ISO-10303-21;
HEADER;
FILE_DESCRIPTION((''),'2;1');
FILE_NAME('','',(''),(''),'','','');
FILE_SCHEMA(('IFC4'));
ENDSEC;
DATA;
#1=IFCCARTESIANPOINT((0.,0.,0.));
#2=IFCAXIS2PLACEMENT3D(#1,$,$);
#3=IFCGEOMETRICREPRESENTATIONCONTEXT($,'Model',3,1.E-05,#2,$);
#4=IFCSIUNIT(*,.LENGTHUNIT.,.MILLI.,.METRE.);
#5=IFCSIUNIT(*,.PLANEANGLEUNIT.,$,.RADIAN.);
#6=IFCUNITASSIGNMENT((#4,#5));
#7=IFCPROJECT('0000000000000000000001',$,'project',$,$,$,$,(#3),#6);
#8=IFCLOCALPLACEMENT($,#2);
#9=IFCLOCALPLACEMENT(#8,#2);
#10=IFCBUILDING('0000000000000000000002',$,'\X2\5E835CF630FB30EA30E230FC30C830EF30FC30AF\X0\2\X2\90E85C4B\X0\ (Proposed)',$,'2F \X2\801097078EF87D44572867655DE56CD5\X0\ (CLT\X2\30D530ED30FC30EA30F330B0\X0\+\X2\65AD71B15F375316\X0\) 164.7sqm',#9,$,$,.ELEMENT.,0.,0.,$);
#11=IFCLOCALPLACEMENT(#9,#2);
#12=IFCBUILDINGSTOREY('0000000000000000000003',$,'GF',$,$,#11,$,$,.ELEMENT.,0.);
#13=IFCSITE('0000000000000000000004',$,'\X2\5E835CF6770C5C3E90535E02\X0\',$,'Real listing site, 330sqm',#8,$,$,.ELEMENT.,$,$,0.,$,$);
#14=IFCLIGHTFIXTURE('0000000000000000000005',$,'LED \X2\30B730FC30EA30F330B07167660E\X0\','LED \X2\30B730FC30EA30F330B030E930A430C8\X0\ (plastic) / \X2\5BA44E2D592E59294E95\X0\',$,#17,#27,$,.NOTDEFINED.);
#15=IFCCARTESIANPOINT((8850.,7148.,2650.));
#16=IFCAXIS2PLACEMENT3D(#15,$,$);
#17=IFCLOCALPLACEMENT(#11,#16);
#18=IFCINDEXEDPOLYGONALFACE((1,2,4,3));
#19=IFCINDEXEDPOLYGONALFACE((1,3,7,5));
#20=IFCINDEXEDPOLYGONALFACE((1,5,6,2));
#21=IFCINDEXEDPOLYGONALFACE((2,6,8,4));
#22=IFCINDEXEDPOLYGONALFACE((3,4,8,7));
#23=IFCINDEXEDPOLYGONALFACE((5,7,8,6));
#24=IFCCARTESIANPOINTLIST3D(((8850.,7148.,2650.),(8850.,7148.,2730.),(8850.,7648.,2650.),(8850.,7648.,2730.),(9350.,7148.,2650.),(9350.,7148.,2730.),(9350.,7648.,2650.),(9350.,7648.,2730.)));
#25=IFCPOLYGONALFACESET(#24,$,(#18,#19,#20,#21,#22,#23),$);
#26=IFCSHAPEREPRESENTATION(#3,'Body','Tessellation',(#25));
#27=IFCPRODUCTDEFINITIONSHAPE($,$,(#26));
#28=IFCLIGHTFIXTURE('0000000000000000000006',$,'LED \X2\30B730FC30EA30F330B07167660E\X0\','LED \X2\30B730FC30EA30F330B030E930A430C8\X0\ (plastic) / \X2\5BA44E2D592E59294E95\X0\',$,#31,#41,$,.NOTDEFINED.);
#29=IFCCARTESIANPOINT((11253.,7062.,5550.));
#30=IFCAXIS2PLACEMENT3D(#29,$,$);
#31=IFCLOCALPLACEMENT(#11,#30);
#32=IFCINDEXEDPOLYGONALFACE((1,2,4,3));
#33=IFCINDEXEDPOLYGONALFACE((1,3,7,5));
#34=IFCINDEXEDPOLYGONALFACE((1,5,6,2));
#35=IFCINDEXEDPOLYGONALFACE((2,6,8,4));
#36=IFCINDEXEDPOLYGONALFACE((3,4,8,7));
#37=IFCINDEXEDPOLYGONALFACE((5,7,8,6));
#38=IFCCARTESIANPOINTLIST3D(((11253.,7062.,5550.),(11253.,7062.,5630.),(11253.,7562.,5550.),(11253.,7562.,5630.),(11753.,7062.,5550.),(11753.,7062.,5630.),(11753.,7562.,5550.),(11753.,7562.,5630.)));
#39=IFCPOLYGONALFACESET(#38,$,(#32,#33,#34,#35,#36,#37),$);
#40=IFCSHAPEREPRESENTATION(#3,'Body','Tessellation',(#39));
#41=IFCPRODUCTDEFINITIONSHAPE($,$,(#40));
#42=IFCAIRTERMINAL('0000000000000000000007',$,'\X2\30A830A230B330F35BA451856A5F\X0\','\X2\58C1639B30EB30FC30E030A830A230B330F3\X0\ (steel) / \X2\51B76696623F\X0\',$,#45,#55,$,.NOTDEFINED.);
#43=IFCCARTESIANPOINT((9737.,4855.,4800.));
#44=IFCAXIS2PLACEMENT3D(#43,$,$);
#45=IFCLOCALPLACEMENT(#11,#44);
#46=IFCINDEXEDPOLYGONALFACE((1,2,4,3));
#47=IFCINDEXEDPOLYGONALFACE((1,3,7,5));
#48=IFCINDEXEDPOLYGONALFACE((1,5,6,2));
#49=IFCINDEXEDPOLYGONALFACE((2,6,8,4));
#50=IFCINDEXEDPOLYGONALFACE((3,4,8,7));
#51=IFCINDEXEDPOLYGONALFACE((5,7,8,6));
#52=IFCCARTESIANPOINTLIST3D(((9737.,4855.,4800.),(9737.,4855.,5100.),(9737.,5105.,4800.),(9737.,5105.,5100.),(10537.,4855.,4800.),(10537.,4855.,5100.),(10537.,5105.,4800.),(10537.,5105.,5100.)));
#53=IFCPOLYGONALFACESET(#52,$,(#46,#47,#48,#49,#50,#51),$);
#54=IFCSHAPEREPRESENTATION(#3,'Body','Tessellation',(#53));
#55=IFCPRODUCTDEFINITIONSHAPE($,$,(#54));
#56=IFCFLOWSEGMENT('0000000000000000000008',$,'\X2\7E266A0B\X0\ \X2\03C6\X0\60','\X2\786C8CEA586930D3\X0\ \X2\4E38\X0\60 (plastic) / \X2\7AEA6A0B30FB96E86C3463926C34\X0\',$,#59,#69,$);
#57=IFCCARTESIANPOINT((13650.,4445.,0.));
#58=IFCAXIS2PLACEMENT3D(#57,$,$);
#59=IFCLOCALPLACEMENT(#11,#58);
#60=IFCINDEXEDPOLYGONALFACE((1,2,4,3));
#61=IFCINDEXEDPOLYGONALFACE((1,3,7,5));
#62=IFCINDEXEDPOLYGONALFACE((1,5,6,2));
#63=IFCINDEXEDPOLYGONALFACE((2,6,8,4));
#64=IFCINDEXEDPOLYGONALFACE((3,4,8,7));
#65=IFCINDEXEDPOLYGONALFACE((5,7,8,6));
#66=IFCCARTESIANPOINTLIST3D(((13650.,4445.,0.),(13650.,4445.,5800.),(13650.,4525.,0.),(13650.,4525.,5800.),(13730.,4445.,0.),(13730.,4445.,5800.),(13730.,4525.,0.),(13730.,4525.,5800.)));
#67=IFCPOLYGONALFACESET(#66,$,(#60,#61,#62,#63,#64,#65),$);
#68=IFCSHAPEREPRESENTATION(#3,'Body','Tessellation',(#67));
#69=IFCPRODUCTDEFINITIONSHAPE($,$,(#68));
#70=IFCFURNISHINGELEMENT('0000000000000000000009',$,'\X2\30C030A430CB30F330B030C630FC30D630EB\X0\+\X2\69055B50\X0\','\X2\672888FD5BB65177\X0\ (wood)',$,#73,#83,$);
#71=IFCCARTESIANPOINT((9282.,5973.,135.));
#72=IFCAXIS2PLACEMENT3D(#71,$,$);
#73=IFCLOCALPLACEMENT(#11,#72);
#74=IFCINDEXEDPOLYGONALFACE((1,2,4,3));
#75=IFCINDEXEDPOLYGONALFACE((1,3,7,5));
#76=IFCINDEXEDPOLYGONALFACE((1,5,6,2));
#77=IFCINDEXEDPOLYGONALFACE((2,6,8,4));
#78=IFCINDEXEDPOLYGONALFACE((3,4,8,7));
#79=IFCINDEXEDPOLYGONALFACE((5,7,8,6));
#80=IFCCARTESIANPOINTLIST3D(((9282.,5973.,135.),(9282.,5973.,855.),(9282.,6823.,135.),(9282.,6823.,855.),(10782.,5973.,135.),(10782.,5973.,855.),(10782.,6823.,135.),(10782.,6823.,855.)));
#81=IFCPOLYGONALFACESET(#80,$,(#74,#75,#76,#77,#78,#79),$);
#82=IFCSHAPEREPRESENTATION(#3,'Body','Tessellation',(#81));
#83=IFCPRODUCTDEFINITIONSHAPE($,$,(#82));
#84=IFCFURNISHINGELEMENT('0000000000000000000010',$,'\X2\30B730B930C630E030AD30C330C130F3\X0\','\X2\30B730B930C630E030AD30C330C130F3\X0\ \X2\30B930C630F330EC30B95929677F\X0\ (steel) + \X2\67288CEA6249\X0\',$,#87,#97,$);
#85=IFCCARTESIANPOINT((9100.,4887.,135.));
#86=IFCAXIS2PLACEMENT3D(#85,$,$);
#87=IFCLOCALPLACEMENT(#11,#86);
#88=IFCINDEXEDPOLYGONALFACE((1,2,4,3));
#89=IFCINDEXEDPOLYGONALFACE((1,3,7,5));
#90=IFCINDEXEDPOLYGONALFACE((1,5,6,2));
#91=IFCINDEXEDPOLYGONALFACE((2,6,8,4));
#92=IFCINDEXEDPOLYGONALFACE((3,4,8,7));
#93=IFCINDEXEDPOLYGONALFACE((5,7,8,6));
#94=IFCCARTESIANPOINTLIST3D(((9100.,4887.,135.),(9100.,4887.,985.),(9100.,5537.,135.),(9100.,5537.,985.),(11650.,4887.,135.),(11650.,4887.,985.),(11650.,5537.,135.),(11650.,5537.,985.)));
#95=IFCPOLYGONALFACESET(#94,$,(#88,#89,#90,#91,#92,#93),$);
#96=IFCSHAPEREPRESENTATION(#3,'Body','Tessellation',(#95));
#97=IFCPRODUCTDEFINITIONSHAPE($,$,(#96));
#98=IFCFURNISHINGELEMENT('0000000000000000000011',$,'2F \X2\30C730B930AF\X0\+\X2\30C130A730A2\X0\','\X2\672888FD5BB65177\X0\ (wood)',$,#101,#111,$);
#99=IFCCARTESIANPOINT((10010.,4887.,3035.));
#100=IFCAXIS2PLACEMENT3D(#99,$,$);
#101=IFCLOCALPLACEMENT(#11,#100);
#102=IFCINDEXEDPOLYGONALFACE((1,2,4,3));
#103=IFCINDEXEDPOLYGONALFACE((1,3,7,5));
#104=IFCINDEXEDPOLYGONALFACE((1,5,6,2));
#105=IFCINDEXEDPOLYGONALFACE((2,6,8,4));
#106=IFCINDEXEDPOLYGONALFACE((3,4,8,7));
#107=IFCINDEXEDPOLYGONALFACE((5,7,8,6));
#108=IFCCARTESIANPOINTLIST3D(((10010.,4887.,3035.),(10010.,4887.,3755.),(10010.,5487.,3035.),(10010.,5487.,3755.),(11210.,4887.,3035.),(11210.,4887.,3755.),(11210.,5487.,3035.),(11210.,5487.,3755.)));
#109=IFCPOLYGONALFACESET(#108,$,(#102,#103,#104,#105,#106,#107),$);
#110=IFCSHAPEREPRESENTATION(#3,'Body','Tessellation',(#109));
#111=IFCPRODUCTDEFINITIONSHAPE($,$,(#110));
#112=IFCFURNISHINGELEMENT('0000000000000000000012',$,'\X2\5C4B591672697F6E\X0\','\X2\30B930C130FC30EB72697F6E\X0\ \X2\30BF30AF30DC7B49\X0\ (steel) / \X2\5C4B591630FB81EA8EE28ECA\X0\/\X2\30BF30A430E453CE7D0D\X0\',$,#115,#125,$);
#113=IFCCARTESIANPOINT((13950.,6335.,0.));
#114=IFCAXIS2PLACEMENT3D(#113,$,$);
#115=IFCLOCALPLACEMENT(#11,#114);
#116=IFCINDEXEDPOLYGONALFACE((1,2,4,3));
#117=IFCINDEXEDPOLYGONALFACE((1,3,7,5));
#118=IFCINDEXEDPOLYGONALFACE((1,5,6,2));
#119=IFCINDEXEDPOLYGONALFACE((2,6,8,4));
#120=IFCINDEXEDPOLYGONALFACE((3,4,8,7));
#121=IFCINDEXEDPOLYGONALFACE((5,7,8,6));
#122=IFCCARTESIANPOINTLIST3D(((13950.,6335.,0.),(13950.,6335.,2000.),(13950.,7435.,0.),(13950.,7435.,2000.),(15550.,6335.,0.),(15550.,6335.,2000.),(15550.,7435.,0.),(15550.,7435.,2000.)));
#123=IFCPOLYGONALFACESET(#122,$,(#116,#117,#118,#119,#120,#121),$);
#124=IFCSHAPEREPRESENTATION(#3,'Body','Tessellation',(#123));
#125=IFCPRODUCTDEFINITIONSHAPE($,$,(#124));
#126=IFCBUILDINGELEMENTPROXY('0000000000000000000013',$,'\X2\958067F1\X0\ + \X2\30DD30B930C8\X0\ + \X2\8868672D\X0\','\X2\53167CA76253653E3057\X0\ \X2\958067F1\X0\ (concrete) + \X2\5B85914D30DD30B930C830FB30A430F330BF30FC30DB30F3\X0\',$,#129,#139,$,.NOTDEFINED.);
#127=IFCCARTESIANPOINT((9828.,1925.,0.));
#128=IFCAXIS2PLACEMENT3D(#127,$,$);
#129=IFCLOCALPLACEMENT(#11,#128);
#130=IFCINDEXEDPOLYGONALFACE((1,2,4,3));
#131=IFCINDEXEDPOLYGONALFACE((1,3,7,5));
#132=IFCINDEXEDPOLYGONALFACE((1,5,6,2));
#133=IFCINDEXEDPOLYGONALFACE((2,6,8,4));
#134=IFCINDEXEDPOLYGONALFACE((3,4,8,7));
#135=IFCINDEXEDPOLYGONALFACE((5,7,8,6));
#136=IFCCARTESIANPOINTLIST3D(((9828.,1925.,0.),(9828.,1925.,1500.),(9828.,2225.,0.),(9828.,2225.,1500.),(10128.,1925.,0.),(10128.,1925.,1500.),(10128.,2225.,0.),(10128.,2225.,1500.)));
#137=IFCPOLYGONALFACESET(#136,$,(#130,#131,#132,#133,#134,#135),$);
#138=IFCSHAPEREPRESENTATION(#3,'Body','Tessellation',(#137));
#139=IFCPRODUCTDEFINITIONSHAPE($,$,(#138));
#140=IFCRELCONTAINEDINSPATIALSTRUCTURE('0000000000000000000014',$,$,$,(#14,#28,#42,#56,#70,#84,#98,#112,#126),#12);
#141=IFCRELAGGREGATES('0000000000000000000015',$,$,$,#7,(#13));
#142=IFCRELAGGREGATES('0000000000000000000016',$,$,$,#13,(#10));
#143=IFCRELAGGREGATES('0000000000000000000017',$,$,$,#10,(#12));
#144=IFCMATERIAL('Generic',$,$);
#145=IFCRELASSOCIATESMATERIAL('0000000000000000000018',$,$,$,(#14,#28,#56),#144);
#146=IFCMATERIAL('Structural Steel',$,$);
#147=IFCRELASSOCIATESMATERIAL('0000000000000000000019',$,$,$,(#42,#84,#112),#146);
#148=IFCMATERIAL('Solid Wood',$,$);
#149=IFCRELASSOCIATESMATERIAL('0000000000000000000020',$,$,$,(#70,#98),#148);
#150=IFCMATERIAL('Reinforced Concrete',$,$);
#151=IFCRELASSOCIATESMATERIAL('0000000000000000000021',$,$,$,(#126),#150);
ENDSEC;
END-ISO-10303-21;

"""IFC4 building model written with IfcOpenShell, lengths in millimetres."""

from ifc_helpers import new_model, si_unit, frame, frame_2d, origin, place, context, project, spatial, rectangle, extrude, material, element, save


model = new_model("IFC4")

# Units and contexts
model_context = context("Model", 3, precision=1e-05, world=origin())
ifc_project = project(units=[si_unit("LENGTHUNIT", "METRE", prefix="MILLI"), si_unit("PLANEANGLEUNIT", "RADIAN")], contexts=[model_context])

# Site, building, storey
site_placement = place(None, origin())
site = spatial("IfcSite", under=ifc_project, at=site_placement, Name="広島県尾道市", ObjectType="Real listing site, 330sqm", CompositionType="ELEMENT", RefElevation=0.0)
building_placement = place(site_placement, origin())
building = spatial("IfcBuilding", under=site, at=building_placement, Name="広島・リモートワーク2部屋 (Proposed)", ObjectType="2F 耐震軸組在来工法 (CLTフローリング+断熱強化) 164.7sqm", CompositionType="ELEMENT", ElevationOfRefHeight=0.0, ElevationOfTerrain=0.0)
storey_placement = place(building_placement, origin())
storey = spatial("IfcBuildingStorey", under=building, at=storey_placement, Name="GF", CompositionType="ELEMENT", Elevation=0.0)

# Shared definitions
ifc_material_1 = material(Name="Solid Wood")

# Shared definitions
ifc_material_2 = material(Name="Reinforced Concrete")

# Shared definitions
ifc_material_3 = material(Name="Structural Steel")

# Shared definitions
ifc_material_4 = material(Name="Generic")

# Light fixtures
light_fixture_1_placement = place(storey_placement, frame((8850.0, 7148.0, 2650.0)))
element("IfcLightFixture", 1, at=light_fixture_1_placement, inside=storey, material=ifc_material_4, Name="LED シーリング照明", Description="LED シーリングライト (plastic) / 室中央天井", PredefinedType="NOTDEFINED", context=model_context, shape_type="SweptSolid", body=[
    extrude(rectangle(XDim=500.0, YDim=500.0, at=frame_2d((250.0, 250.0))), frame((8850.0, 7148.0, 2650.0)), (0.0, 0.0, 1.0), 80.0),
])
light_fixture_2_placement = place(storey_placement, frame((11253.0, 7062.0, 5550.0)))
element("IfcLightFixture", 2, at=light_fixture_2_placement, inside=storey, material=ifc_material_4, Name="LED シーリング照明", Description="LED シーリングライト (plastic) / 室中央天井", PredefinedType="NOTDEFINED", context=model_context, shape_type="SweptSolid", body=[
    extrude(rectangle(XDim=500.0, YDim=500.0, at=frame_2d((250.0, 250.0))), frame((11253.0, 7062.0, 5550.0)), (0.0, 0.0, 1.0), 80.0),
])

# Air terminal
air_terminal_placement = place(storey_placement, frame((9737.0, 4855.0, 4800.0)))
element("IfcAirTerminal", 3, at=air_terminal_placement, inside=storey, material=ifc_material_3, Name="エアコン室内機", Description="壁掛ルームエアコン (steel) / 冷暖房", PredefinedType="NOTDEFINED", context=model_context, shape_type="SweptSolid", body=[
    extrude(rectangle(XDim=800.0, YDim=250.0, at=frame_2d((400.0, 125.0))), frame((9737.0, 4855.0, 4800.0)), (0.0, 0.0, 1.0), 300.0),
])

# Flow segment
flow_segment_placement = place(storey_placement, frame((13650.0, 4445.0, 0.0)))
element("IfcFlowSegment", 4, at=flow_segment_placement, inside=storey, material=ifc_material_4, Name="縦樋 φ60", Description="硬質塩ビ 丸60 (plastic) / 竪樋・雨水排水", context=model_context, shape_type="SweptSolid", body=[
    extrude(rectangle(XDim=80.0, YDim=80.0, at=frame_2d((40.0, 40.0))), frame((13650.0, 4445.0, 0.0)), (0.0, 0.0, 1.0), 5800.0),
])

# Furnishing elements
furnishing_1_placement = place(storey_placement, frame((9282.0, 5973.0, 135.0)))
element("IfcFurnishingElement", 5, at=furnishing_1_placement, inside=storey, material=ifc_material_1, Name="ダイニングテーブル+椅子", Description="木製家具 (wood)", context=model_context, shape_type="SweptSolid", body=[
    extrude(rectangle(XDim=1500.0, YDim=850.0, at=frame_2d((750.0, 425.0))), frame((9282.0, 5973.0, 135.0)), (0.0, 0.0, 1.0), 720.0),
])
furnishing_2_placement = place(storey_placement, frame((9100.0, 4887.0, 135.0)))
element("IfcFurnishingElement", 6, at=furnishing_2_placement, inside=storey, material=ifc_material_3, Name="システムキッチン", Description="システムキッチン ステンレス天板 (steel) + 木質扉", context=model_context, shape_type="SweptSolid", body=[
    extrude(rectangle(XDim=2550.0, YDim=650.0, at=frame_2d((1275.0, 325.0))), frame((9100.0, 4887.0, 135.0)), (0.0, 0.0, 1.0), 850.0),
])
furnishing_3_placement = place(storey_placement, frame((10010.0, 4887.0, 3035.0)))
element("IfcFurnishingElement", 7, at=furnishing_3_placement, inside=storey, material=ifc_material_1, Name="2F デスク+チェア", Description="木製家具 (wood)", context=model_context, shape_type="SweptSolid", body=[
    extrude(rectangle(XDim=1200.0, YDim=600.0, at=frame_2d((600.0, 300.0))), frame((10010.0, 4887.0, 3035.0)), (0.0, 0.0, 1.0), 720.0),
])
furnishing_4_placement = place(storey_placement, frame((13950.0, 6335.0, 0.0)))
element("IfcFurnishingElement", 8, at=furnishing_4_placement, inside=storey, material=ifc_material_3, Name="屋外物置", Description="スチール物置 タクボ等 (steel) / 屋外・自転車/タイヤ収納", context=model_context, shape_type="SweptSolid", body=[
    extrude(rectangle(XDim=1600.0, YDim=1100.0, at=frame_2d((800.0, 550.0))), frame((13950.0, 6335.0, 0.0)), (0.0, 0.0, 1.0), 2000.0),
])

# Building element proxy
proxy_placement = place(storey_placement, frame((9828.0, 1925.0, 0.0)))
element("IfcBuildingElementProxy", 9, at=proxy_placement, inside=storey, material=ifc_material_2, Name="門柱 + ポスト + 表札", Description="化粧打放し 門柱 (concrete) + 宅配ポスト・インターホン", PredefinedType="NOTDEFINED", context=model_context, shape_type="SweptSolid", body=[
    extrude(rectangle(XDim=300.0, YDim=300.0, at=frame_2d((150.0, 150.0))), frame((9828.0, 1925.0, 0.0)), (0.0, 0.0, 1.0), 1500.0),
])

save(model, "model.ifc")
